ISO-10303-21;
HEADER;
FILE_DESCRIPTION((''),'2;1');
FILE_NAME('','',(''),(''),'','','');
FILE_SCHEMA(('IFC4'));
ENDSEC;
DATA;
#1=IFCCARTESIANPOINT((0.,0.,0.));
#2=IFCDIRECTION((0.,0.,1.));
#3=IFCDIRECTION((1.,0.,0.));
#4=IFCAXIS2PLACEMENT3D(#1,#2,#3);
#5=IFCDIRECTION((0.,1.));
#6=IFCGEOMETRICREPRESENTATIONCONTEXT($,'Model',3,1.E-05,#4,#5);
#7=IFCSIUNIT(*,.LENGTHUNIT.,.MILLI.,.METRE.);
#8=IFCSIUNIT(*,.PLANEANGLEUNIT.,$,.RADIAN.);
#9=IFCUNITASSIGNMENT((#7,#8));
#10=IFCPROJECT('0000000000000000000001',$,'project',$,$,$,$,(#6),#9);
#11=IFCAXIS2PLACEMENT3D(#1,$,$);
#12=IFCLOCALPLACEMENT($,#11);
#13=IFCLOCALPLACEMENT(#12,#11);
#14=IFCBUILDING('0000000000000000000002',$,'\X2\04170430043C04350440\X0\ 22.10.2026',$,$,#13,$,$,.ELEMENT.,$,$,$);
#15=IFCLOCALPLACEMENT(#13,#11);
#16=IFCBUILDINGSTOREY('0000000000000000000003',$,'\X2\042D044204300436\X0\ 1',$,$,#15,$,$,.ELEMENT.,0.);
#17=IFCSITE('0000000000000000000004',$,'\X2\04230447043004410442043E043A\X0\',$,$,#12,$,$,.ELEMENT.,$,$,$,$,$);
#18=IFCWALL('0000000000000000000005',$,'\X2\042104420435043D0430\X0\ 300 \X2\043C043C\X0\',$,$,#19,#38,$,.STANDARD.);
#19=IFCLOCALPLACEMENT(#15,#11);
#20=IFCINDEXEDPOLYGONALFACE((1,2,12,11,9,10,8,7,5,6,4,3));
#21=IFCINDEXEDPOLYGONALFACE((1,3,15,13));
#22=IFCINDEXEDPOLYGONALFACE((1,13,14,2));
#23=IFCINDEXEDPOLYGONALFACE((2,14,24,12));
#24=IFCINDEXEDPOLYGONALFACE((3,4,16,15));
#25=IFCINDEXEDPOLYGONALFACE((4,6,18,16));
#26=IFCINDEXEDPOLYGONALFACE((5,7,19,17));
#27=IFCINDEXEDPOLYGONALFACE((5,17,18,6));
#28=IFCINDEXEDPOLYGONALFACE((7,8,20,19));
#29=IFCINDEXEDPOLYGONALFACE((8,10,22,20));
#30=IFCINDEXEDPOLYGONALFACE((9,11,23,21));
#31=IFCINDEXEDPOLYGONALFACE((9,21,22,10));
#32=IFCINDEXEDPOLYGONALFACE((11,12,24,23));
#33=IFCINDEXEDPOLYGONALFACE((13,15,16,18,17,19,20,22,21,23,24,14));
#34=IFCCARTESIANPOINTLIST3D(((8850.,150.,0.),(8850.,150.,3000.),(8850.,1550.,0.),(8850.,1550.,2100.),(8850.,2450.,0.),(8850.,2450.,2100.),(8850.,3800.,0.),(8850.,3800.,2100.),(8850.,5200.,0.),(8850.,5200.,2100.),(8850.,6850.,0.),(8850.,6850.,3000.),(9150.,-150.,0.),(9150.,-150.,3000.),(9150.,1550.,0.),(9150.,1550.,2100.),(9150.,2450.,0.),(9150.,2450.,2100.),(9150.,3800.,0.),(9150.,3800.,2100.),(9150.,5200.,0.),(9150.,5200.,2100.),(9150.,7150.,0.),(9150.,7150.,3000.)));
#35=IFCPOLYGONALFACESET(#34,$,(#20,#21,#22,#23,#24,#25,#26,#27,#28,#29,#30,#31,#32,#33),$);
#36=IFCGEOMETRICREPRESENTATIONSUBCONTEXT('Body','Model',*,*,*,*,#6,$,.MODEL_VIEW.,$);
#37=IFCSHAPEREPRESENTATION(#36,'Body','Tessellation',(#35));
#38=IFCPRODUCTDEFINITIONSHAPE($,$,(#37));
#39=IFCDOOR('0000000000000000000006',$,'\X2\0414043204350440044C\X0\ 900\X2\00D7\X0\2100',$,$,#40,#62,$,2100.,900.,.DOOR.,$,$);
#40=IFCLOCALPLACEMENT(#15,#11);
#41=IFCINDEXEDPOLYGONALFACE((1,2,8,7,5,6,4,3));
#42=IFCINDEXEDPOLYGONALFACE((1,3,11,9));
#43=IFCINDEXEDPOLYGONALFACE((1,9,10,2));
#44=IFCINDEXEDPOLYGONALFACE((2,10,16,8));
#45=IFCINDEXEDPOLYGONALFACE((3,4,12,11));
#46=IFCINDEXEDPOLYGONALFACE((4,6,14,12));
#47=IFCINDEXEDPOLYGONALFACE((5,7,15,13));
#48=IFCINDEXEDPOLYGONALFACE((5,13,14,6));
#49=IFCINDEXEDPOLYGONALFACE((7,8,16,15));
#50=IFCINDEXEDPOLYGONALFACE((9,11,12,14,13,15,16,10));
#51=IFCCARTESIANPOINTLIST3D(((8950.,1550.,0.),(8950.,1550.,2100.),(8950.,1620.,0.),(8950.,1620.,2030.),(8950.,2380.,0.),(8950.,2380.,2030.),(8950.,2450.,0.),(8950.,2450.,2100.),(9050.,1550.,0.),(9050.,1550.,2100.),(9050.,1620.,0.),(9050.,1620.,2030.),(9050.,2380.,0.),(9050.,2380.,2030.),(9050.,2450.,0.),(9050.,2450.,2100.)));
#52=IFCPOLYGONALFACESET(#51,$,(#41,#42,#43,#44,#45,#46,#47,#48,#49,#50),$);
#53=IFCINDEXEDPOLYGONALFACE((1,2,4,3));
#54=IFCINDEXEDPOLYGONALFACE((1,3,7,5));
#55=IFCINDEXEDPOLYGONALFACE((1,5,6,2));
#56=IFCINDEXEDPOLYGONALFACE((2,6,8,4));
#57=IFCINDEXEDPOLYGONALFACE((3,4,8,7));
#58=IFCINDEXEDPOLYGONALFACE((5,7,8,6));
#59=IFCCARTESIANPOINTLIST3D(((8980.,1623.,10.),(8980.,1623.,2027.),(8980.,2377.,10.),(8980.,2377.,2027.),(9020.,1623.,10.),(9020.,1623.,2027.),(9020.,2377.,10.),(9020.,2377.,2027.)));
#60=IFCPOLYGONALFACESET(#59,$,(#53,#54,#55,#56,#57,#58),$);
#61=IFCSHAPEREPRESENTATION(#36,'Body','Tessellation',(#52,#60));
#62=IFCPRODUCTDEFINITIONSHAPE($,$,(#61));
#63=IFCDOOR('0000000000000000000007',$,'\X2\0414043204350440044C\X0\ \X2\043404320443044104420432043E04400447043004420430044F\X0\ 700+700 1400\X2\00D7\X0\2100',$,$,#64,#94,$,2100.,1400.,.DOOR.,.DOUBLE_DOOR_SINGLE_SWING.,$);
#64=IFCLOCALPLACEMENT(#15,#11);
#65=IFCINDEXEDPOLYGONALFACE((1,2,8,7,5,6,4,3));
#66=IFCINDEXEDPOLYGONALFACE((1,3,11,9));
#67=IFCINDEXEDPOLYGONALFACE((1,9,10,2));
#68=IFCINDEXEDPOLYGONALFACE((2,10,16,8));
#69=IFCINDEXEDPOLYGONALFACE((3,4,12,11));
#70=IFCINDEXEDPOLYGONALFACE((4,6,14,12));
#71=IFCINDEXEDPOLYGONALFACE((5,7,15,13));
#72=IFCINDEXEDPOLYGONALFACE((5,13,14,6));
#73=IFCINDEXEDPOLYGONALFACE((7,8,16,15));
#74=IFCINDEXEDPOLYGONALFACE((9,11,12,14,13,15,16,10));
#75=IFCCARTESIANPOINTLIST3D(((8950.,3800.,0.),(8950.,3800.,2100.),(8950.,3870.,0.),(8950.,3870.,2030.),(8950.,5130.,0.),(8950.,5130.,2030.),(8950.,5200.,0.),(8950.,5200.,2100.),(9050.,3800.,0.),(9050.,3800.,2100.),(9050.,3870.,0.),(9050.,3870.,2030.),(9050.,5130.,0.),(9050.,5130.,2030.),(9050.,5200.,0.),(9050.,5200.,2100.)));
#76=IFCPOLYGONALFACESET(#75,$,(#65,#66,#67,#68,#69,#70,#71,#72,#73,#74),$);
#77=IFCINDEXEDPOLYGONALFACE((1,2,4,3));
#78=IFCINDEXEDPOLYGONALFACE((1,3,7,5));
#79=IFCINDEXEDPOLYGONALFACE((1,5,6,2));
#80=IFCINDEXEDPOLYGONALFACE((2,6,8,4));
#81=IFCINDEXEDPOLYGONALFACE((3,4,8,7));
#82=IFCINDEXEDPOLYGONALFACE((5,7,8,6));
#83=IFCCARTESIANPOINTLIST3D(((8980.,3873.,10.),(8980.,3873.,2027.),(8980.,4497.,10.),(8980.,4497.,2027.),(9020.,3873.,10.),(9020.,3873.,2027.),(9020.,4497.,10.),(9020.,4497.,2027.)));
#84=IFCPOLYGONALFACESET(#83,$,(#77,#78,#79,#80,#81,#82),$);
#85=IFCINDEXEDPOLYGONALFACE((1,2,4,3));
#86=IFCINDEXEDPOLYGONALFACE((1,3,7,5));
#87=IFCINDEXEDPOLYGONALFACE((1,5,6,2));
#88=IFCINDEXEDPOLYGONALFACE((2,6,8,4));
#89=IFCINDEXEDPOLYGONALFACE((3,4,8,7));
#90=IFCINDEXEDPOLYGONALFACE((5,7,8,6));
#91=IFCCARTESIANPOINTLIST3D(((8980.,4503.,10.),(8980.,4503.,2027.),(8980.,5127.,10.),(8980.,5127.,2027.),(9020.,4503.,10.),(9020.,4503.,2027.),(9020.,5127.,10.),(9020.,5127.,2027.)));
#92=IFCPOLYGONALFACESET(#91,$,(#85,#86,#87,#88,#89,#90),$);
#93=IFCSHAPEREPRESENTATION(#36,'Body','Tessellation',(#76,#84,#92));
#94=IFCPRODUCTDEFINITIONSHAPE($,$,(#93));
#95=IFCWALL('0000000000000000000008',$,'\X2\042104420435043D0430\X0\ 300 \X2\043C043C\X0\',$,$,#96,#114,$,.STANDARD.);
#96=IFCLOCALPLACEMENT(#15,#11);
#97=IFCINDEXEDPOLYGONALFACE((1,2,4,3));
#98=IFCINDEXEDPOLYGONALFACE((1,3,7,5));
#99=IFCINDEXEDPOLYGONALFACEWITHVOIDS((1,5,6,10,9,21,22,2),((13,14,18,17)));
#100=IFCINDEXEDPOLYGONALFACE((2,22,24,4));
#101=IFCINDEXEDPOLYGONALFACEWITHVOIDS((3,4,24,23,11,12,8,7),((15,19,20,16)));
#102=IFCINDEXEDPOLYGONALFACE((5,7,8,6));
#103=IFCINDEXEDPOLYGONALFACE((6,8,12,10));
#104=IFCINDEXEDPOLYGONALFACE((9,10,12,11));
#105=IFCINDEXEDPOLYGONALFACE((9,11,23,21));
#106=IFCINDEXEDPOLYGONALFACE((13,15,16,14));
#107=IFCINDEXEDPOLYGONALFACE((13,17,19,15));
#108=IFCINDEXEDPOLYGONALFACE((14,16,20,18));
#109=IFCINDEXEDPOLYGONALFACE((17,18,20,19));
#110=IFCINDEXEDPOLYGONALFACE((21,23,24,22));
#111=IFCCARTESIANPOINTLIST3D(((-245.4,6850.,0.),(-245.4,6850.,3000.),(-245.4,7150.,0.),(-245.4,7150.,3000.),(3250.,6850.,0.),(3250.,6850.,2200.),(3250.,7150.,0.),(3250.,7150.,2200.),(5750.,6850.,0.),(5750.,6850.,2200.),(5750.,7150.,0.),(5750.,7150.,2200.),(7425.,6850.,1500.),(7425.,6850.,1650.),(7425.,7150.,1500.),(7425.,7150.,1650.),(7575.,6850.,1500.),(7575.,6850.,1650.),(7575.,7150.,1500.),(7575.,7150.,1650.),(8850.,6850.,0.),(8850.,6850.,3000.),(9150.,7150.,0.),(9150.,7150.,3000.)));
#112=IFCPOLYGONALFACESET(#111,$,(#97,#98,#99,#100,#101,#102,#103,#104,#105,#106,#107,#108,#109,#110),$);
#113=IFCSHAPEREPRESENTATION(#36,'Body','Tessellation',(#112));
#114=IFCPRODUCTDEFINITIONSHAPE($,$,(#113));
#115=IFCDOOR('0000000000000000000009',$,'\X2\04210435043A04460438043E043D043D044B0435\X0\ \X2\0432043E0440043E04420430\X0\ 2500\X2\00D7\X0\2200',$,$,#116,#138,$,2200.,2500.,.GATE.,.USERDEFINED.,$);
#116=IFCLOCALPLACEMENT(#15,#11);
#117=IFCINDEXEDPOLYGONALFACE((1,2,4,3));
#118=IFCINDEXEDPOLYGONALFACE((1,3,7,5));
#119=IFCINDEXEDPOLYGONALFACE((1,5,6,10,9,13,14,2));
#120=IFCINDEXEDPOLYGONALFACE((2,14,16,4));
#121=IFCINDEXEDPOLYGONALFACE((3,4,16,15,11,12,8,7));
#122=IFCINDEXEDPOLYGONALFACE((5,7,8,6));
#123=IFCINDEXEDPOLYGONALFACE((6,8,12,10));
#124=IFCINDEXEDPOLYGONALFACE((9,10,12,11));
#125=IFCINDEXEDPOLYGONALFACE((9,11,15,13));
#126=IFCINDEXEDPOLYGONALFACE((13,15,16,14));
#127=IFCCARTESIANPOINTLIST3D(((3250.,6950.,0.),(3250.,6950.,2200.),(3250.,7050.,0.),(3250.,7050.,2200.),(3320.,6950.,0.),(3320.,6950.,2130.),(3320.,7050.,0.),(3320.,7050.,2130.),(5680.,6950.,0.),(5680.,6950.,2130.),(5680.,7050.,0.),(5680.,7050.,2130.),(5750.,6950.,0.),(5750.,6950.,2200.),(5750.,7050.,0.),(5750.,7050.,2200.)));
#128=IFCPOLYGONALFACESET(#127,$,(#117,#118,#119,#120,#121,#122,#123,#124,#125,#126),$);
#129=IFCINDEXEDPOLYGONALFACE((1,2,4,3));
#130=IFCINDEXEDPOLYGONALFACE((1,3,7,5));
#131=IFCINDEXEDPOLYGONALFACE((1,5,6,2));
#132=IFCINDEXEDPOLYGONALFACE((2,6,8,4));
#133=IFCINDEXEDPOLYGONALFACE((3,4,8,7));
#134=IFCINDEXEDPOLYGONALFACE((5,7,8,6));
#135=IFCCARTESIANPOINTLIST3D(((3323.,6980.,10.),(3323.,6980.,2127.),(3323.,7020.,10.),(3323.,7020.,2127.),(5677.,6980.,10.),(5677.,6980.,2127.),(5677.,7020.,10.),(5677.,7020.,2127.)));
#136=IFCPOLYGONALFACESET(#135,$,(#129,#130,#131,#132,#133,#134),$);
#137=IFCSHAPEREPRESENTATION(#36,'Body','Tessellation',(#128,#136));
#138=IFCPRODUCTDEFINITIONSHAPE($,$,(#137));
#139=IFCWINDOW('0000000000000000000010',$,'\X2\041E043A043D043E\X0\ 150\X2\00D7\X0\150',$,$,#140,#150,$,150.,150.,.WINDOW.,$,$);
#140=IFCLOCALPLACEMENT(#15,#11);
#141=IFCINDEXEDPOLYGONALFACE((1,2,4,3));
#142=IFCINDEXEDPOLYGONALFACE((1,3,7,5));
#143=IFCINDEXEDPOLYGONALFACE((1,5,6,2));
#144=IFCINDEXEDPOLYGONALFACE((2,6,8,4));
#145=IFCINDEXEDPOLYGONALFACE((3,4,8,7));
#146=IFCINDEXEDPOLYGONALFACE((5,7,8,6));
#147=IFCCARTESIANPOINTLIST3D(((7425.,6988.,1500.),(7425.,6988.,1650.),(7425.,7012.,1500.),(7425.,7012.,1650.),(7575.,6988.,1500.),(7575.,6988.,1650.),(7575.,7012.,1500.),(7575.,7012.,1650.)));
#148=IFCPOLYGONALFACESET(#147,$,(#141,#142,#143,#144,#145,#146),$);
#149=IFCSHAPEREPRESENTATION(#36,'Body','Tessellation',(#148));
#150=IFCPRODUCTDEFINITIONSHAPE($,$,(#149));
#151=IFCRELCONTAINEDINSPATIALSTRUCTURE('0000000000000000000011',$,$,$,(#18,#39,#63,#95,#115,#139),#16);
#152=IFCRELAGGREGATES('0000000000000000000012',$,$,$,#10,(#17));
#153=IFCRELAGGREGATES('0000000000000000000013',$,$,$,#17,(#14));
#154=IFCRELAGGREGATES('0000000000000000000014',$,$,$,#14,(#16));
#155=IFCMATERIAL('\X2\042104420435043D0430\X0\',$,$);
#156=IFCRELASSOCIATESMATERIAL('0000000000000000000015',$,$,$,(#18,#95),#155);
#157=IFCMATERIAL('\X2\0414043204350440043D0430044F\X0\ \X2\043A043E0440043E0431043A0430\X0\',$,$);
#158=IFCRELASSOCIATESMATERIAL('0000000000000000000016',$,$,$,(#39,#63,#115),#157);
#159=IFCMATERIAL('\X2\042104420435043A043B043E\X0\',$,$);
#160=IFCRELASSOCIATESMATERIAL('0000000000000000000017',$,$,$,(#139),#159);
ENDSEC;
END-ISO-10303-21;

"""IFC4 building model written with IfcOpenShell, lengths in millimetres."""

from ifc_helpers import new_model, si_unit, direction, frame, origin, origin_with_axes, place, context, subcontext, project, spatial, polyline, outline, extrude, material, element, fill, save


model = new_model("IFC4")

# Units and contexts
model_context = context("Model", 3, precision=1e-05, world=origin_with_axes(), true_north=direction((0.0, 1.0)))
body_context = subcontext(model_context, "Body", "Model", "MODEL_VIEW")
ifc_project = project(units=[si_unit("LENGTHUNIT", "METRE", prefix="MILLI"), si_unit("PLANEANGLEUNIT", "RADIAN")], contexts=[model_context])

# Site, building, storey
site_placement = place(None, origin())
site = spatial("IfcSite", under=ifc_project, at=site_placement, Name="Участок", CompositionType="ELEMENT")
building_placement = place(site_placement, origin())
building = spatial("IfcBuilding", under=site, at=building_placement, Name="Замер 22.10.2026", CompositionType="ELEMENT")
storey_placement = place(building_placement, origin())
storey = spatial("IfcBuildingStorey", under=building, at=storey_placement, Name="Этаж 1", CompositionType="ELEMENT", Elevation=0.0)

# Shared definitions
ifc_material_1 = material(Name="Стена")

# Wall, openings, doors
wall_1_placement = place(storey_placement, origin())
wall_1 = element("IfcWall", 1, at=wall_1_placement, inside=storey, material=ifc_material_1, Name="Стена 300 мм", PredefinedType="STANDARD", context=body_context, shape_type="SweptSolid", body=[
    extrude(outline(polyline([(9150.0, -150.0), (9150.0, 7150.0), (8850.0, 6850.0), (8850.0, 150.0), (9150.0, -150.0)])), origin(), (0.0, 0.0, 1.0), 3000.0),
])
opening_1_placement = place(storey_placement, frame((9000.0, 1550.0, 0.0), z_axis=(0.0, 0.0, 1.0), x_axis=(0.0, 1.0, 0.0)))
opening_1 = element("IfcOpeningElement", 2, at=opening_1_placement, cuts=wall_1, PredefinedType="OPENING", context=body_context, shape_type="SweptSolid", body=[
    extrude(outline(polyline([(0.0, -250.0), (900.0, -250.0), (900.0, 250.0), (0.0, 250.0), (0.0, -250.0)])), origin(), (0.0, 0.0, 1.0), 2100.0),
])
opening_2_placement = place(storey_placement, frame((9000.0, 3800.0, 0.0), z_axis=(0.0, 0.0, 1.0), x_axis=(0.0, 1.0, 0.0)))
opening_2 = element("IfcOpeningElement", 3, at=opening_2_placement, cuts=wall_1, PredefinedType="OPENING", context=body_context, shape_type="SweptSolid", body=[
    extrude(outline(polyline([(0.0, -250.0), (1400.0, -250.0), (1400.0, 250.0), (0.0, 250.0), (0.0, -250.0)])), origin(), (0.0, 0.0, 1.0), 2100.0),
])
ifc_material_2 = material(Name="Дверная коробка")
door_1_placement = place(storey_placement, frame((9000.0, 1550.0, 0.0), z_axis=(0.0, 0.0, 1.0), x_axis=(0.0, 1.0, 0.0)))
door_1 = element("IfcDoor", 4, at=door_1_placement, inside=storey, material=ifc_material_2, Name="Дверь 900×2100", OverallHeight=2100.0, OverallWidth=900.0, PredefinedType="DOOR", context=body_context, shape_type="SweptSolid", body=[
    extrude(outline(polyline([(0.0, 0.0), (70.0, 0.0), (70.0, 2030.0), (830.0, 2030.0), (830.0, 0.0), (900.0, 0.0), (900.0, 2100.0), (0.0, 2100.0), (0.0, 0.0)])), frame((0.0, 50.0, 0.0), z_axis=(0.0, -1.0, 0.0), x_axis=(1.0, 0.0, 0.0)), (0.0, 0.0, 1.0), 100.0),
    extrude(outline(polyline([(73.0, 10.0), (827.0, 10.0), (827.0, 2027.0), (73.0, 2027.0), (73.0, 10.0)])), frame((0.0, 20.0, 0.0), z_axis=(0.0, -1.0, 0.0), x_axis=(1.0, 0.0, 0.0)), (0.0, 0.0, 1.0), 40.0),
])
fill(opening_1, door_1)
door_2_placement = place(storey_placement, frame((9000.0, 3800.0, 0.0), z_axis=(0.0, 0.0, 1.0), x_axis=(0.0, 1.0, 0.0)))
door_2 = element("IfcDoor", 5, at=door_2_placement, inside=storey, material=ifc_material_2, Name="Дверь двустворчатая 700+700 1400×2100", OperationType="DOUBLE_DOOR_SINGLE_SWING", OverallHeight=2100.0, OverallWidth=1400.0, PredefinedType="DOOR", context=body_context, shape_type="SweptSolid", body=[
    extrude(outline(polyline([(0.0, 0.0), (70.0, 0.0), (70.0, 2030.0), (1330.0, 2030.0), (1330.0, 0.0), (1400.0, 0.0), (1400.0, 2100.0), (0.0, 2100.0), (0.0, 0.0)])), frame((0.0, 50.0, 0.0), z_axis=(0.0, -1.0, 0.0), x_axis=(1.0, 0.0, 0.0)), (0.0, 0.0, 1.0), 100.0),
    extrude(outline(polyline([(73.0, 10.0), (697.0, 10.0), (697.0, 2027.0), (73.0, 2027.0), (73.0, 10.0)])), frame((0.0, 20.0, 0.0), z_axis=(0.0, -1.0, 0.0), x_axis=(1.0, 0.0, 0.0)), (0.0, 0.0, 1.0), 40.0),
    extrude(outline(polyline([(703.0, 10.0), (1327.0, 10.0), (1327.0, 2027.0), (703.0, 2027.0), (703.0, 10.0)])), frame((0.0, 20.0, 0.0), z_axis=(0.0, -1.0, 0.0), x_axis=(1.0, 0.0, 0.0)), (0.0, 0.0, 1.0), 40.0),
])
fill(opening_2, door_2)

# Wall, openings, door, window
wall_2_placement = place(storey_placement, origin())
wall_2 = element("IfcWall", 6, at=wall_2_placement, inside=storey, material=ifc_material_1, Name="Стена 300 мм", PredefinedType="STANDARD", context=body_context, shape_type="SweptSolid", body=[
    extrude(outline(polyline([(9150.0, 7150.0), (-245.4, 7150.0), (-245.4, 6850.0), (8850.0, 6850.0), (9150.0, 7150.0)])), origin(), (0.0, 0.0, 1.0), 3000.0),
])
opening_3_placement = place(storey_placement, frame((5750.0, 7000.0, 0.0), z_axis=(0.0, 0.0, 1.0), x_axis=(-1.0, 0.0, 0.0)))
opening_3 = element("IfcOpeningElement", 7, at=opening_3_placement, cuts=wall_2, PredefinedType="OPENING", context=body_context, shape_type="SweptSolid", body=[
    extrude(outline(polyline([(0.0, -250.0), (2500.0, -250.0), (2500.0, 250.0), (0.0, 250.0), (0.0, -250.0)])), origin(), (0.0, 0.0, 1.0), 2200.0),
])
opening_4_placement = place(storey_placement, frame((7575.0, 7000.0, 1500.0), z_axis=(0.0, 0.0, 1.0), x_axis=(-1.0, 0.0, 0.0)))
opening_4 = element("IfcOpeningElement", 8, at=opening_4_placement, cuts=wall_2, PredefinedType="OPENING", context=body_context, shape_type="SweptSolid", body=[
    extrude(outline(polyline([(0.0, -250.0), (150.0, -250.0), (150.0, 250.0), (0.0, 250.0), (0.0, -250.0)])), origin(), (0.0, 0.0, 1.0), 150.0),
])
door_3_placement = place(storey_placement, frame((5750.0, 7000.0, 0.0), z_axis=(0.0, 0.0, 1.0), x_axis=(-1.0, 0.0, 0.0)))
door_3 = element("IfcDoor", 9, at=door_3_placement, inside=storey, material=ifc_material_2, Name="Секционные ворота 2500×2200", OperationType="USERDEFINED", OverallHeight=2200.0, OverallWidth=2500.0, PredefinedType="GATE", context=body_context, shape_type="SweptSolid", body=[
    extrude(outline(polyline([(0.0, 0.0), (70.0, 0.0), (70.0, 2130.0), (2430.0, 2130.0), (2430.0, 0.0), (2500.0, 0.0), (2500.0, 2200.0), (0.0, 2200.0), (0.0, 0.0)])), frame((0.0, 50.0, 0.0), z_axis=(0.0, -1.0, 0.0), x_axis=(1.0, 0.0, 0.0)), (0.0, 0.0, 1.0), 100.0),
    extrude(outline(polyline([(73.0, 10.0), (2427.0, 10.0), (2427.0, 2127.0), (73.0, 2127.0), (73.0, 10.0)])), frame((0.0, 20.0, 0.0), z_axis=(0.0, -1.0, 0.0), x_axis=(1.0, 0.0, 0.0)), (0.0, 0.0, 1.0), 40.0),
])
fill(opening_3, door_3)
ifc_material_3 = material(Name="Стекло")
window_1_placement = place(storey_placement, frame((7575.0, 7000.0, 1500.0), z_axis=(0.0, 0.0, 1.0), x_axis=(-1.0, 0.0, 0.0)))
window_1 = element("IfcWindow", 10, at=window_1_placement, inside=storey, material=ifc_material_3, Name="Окно 150×150", OverallHeight=150.0, OverallWidth=150.0, PredefinedType="WINDOW", context=body_context, shape_type="SweptSolid", body=[
    extrude(outline(polyline([(0.0, 0.0), (150.0, 0.0), (150.0, 150.0), (0.0, 150.0), (0.0, 0.0)])), frame((0.0, 12.0, 0.0), z_axis=(0.0, -1.0, 0.0), x_axis=(1.0, 0.0, 0.0)), (0.0, 0.0, 1.0), 24.0),
])
fill(opening_4, window_1)

save(model, "model.ifc")
